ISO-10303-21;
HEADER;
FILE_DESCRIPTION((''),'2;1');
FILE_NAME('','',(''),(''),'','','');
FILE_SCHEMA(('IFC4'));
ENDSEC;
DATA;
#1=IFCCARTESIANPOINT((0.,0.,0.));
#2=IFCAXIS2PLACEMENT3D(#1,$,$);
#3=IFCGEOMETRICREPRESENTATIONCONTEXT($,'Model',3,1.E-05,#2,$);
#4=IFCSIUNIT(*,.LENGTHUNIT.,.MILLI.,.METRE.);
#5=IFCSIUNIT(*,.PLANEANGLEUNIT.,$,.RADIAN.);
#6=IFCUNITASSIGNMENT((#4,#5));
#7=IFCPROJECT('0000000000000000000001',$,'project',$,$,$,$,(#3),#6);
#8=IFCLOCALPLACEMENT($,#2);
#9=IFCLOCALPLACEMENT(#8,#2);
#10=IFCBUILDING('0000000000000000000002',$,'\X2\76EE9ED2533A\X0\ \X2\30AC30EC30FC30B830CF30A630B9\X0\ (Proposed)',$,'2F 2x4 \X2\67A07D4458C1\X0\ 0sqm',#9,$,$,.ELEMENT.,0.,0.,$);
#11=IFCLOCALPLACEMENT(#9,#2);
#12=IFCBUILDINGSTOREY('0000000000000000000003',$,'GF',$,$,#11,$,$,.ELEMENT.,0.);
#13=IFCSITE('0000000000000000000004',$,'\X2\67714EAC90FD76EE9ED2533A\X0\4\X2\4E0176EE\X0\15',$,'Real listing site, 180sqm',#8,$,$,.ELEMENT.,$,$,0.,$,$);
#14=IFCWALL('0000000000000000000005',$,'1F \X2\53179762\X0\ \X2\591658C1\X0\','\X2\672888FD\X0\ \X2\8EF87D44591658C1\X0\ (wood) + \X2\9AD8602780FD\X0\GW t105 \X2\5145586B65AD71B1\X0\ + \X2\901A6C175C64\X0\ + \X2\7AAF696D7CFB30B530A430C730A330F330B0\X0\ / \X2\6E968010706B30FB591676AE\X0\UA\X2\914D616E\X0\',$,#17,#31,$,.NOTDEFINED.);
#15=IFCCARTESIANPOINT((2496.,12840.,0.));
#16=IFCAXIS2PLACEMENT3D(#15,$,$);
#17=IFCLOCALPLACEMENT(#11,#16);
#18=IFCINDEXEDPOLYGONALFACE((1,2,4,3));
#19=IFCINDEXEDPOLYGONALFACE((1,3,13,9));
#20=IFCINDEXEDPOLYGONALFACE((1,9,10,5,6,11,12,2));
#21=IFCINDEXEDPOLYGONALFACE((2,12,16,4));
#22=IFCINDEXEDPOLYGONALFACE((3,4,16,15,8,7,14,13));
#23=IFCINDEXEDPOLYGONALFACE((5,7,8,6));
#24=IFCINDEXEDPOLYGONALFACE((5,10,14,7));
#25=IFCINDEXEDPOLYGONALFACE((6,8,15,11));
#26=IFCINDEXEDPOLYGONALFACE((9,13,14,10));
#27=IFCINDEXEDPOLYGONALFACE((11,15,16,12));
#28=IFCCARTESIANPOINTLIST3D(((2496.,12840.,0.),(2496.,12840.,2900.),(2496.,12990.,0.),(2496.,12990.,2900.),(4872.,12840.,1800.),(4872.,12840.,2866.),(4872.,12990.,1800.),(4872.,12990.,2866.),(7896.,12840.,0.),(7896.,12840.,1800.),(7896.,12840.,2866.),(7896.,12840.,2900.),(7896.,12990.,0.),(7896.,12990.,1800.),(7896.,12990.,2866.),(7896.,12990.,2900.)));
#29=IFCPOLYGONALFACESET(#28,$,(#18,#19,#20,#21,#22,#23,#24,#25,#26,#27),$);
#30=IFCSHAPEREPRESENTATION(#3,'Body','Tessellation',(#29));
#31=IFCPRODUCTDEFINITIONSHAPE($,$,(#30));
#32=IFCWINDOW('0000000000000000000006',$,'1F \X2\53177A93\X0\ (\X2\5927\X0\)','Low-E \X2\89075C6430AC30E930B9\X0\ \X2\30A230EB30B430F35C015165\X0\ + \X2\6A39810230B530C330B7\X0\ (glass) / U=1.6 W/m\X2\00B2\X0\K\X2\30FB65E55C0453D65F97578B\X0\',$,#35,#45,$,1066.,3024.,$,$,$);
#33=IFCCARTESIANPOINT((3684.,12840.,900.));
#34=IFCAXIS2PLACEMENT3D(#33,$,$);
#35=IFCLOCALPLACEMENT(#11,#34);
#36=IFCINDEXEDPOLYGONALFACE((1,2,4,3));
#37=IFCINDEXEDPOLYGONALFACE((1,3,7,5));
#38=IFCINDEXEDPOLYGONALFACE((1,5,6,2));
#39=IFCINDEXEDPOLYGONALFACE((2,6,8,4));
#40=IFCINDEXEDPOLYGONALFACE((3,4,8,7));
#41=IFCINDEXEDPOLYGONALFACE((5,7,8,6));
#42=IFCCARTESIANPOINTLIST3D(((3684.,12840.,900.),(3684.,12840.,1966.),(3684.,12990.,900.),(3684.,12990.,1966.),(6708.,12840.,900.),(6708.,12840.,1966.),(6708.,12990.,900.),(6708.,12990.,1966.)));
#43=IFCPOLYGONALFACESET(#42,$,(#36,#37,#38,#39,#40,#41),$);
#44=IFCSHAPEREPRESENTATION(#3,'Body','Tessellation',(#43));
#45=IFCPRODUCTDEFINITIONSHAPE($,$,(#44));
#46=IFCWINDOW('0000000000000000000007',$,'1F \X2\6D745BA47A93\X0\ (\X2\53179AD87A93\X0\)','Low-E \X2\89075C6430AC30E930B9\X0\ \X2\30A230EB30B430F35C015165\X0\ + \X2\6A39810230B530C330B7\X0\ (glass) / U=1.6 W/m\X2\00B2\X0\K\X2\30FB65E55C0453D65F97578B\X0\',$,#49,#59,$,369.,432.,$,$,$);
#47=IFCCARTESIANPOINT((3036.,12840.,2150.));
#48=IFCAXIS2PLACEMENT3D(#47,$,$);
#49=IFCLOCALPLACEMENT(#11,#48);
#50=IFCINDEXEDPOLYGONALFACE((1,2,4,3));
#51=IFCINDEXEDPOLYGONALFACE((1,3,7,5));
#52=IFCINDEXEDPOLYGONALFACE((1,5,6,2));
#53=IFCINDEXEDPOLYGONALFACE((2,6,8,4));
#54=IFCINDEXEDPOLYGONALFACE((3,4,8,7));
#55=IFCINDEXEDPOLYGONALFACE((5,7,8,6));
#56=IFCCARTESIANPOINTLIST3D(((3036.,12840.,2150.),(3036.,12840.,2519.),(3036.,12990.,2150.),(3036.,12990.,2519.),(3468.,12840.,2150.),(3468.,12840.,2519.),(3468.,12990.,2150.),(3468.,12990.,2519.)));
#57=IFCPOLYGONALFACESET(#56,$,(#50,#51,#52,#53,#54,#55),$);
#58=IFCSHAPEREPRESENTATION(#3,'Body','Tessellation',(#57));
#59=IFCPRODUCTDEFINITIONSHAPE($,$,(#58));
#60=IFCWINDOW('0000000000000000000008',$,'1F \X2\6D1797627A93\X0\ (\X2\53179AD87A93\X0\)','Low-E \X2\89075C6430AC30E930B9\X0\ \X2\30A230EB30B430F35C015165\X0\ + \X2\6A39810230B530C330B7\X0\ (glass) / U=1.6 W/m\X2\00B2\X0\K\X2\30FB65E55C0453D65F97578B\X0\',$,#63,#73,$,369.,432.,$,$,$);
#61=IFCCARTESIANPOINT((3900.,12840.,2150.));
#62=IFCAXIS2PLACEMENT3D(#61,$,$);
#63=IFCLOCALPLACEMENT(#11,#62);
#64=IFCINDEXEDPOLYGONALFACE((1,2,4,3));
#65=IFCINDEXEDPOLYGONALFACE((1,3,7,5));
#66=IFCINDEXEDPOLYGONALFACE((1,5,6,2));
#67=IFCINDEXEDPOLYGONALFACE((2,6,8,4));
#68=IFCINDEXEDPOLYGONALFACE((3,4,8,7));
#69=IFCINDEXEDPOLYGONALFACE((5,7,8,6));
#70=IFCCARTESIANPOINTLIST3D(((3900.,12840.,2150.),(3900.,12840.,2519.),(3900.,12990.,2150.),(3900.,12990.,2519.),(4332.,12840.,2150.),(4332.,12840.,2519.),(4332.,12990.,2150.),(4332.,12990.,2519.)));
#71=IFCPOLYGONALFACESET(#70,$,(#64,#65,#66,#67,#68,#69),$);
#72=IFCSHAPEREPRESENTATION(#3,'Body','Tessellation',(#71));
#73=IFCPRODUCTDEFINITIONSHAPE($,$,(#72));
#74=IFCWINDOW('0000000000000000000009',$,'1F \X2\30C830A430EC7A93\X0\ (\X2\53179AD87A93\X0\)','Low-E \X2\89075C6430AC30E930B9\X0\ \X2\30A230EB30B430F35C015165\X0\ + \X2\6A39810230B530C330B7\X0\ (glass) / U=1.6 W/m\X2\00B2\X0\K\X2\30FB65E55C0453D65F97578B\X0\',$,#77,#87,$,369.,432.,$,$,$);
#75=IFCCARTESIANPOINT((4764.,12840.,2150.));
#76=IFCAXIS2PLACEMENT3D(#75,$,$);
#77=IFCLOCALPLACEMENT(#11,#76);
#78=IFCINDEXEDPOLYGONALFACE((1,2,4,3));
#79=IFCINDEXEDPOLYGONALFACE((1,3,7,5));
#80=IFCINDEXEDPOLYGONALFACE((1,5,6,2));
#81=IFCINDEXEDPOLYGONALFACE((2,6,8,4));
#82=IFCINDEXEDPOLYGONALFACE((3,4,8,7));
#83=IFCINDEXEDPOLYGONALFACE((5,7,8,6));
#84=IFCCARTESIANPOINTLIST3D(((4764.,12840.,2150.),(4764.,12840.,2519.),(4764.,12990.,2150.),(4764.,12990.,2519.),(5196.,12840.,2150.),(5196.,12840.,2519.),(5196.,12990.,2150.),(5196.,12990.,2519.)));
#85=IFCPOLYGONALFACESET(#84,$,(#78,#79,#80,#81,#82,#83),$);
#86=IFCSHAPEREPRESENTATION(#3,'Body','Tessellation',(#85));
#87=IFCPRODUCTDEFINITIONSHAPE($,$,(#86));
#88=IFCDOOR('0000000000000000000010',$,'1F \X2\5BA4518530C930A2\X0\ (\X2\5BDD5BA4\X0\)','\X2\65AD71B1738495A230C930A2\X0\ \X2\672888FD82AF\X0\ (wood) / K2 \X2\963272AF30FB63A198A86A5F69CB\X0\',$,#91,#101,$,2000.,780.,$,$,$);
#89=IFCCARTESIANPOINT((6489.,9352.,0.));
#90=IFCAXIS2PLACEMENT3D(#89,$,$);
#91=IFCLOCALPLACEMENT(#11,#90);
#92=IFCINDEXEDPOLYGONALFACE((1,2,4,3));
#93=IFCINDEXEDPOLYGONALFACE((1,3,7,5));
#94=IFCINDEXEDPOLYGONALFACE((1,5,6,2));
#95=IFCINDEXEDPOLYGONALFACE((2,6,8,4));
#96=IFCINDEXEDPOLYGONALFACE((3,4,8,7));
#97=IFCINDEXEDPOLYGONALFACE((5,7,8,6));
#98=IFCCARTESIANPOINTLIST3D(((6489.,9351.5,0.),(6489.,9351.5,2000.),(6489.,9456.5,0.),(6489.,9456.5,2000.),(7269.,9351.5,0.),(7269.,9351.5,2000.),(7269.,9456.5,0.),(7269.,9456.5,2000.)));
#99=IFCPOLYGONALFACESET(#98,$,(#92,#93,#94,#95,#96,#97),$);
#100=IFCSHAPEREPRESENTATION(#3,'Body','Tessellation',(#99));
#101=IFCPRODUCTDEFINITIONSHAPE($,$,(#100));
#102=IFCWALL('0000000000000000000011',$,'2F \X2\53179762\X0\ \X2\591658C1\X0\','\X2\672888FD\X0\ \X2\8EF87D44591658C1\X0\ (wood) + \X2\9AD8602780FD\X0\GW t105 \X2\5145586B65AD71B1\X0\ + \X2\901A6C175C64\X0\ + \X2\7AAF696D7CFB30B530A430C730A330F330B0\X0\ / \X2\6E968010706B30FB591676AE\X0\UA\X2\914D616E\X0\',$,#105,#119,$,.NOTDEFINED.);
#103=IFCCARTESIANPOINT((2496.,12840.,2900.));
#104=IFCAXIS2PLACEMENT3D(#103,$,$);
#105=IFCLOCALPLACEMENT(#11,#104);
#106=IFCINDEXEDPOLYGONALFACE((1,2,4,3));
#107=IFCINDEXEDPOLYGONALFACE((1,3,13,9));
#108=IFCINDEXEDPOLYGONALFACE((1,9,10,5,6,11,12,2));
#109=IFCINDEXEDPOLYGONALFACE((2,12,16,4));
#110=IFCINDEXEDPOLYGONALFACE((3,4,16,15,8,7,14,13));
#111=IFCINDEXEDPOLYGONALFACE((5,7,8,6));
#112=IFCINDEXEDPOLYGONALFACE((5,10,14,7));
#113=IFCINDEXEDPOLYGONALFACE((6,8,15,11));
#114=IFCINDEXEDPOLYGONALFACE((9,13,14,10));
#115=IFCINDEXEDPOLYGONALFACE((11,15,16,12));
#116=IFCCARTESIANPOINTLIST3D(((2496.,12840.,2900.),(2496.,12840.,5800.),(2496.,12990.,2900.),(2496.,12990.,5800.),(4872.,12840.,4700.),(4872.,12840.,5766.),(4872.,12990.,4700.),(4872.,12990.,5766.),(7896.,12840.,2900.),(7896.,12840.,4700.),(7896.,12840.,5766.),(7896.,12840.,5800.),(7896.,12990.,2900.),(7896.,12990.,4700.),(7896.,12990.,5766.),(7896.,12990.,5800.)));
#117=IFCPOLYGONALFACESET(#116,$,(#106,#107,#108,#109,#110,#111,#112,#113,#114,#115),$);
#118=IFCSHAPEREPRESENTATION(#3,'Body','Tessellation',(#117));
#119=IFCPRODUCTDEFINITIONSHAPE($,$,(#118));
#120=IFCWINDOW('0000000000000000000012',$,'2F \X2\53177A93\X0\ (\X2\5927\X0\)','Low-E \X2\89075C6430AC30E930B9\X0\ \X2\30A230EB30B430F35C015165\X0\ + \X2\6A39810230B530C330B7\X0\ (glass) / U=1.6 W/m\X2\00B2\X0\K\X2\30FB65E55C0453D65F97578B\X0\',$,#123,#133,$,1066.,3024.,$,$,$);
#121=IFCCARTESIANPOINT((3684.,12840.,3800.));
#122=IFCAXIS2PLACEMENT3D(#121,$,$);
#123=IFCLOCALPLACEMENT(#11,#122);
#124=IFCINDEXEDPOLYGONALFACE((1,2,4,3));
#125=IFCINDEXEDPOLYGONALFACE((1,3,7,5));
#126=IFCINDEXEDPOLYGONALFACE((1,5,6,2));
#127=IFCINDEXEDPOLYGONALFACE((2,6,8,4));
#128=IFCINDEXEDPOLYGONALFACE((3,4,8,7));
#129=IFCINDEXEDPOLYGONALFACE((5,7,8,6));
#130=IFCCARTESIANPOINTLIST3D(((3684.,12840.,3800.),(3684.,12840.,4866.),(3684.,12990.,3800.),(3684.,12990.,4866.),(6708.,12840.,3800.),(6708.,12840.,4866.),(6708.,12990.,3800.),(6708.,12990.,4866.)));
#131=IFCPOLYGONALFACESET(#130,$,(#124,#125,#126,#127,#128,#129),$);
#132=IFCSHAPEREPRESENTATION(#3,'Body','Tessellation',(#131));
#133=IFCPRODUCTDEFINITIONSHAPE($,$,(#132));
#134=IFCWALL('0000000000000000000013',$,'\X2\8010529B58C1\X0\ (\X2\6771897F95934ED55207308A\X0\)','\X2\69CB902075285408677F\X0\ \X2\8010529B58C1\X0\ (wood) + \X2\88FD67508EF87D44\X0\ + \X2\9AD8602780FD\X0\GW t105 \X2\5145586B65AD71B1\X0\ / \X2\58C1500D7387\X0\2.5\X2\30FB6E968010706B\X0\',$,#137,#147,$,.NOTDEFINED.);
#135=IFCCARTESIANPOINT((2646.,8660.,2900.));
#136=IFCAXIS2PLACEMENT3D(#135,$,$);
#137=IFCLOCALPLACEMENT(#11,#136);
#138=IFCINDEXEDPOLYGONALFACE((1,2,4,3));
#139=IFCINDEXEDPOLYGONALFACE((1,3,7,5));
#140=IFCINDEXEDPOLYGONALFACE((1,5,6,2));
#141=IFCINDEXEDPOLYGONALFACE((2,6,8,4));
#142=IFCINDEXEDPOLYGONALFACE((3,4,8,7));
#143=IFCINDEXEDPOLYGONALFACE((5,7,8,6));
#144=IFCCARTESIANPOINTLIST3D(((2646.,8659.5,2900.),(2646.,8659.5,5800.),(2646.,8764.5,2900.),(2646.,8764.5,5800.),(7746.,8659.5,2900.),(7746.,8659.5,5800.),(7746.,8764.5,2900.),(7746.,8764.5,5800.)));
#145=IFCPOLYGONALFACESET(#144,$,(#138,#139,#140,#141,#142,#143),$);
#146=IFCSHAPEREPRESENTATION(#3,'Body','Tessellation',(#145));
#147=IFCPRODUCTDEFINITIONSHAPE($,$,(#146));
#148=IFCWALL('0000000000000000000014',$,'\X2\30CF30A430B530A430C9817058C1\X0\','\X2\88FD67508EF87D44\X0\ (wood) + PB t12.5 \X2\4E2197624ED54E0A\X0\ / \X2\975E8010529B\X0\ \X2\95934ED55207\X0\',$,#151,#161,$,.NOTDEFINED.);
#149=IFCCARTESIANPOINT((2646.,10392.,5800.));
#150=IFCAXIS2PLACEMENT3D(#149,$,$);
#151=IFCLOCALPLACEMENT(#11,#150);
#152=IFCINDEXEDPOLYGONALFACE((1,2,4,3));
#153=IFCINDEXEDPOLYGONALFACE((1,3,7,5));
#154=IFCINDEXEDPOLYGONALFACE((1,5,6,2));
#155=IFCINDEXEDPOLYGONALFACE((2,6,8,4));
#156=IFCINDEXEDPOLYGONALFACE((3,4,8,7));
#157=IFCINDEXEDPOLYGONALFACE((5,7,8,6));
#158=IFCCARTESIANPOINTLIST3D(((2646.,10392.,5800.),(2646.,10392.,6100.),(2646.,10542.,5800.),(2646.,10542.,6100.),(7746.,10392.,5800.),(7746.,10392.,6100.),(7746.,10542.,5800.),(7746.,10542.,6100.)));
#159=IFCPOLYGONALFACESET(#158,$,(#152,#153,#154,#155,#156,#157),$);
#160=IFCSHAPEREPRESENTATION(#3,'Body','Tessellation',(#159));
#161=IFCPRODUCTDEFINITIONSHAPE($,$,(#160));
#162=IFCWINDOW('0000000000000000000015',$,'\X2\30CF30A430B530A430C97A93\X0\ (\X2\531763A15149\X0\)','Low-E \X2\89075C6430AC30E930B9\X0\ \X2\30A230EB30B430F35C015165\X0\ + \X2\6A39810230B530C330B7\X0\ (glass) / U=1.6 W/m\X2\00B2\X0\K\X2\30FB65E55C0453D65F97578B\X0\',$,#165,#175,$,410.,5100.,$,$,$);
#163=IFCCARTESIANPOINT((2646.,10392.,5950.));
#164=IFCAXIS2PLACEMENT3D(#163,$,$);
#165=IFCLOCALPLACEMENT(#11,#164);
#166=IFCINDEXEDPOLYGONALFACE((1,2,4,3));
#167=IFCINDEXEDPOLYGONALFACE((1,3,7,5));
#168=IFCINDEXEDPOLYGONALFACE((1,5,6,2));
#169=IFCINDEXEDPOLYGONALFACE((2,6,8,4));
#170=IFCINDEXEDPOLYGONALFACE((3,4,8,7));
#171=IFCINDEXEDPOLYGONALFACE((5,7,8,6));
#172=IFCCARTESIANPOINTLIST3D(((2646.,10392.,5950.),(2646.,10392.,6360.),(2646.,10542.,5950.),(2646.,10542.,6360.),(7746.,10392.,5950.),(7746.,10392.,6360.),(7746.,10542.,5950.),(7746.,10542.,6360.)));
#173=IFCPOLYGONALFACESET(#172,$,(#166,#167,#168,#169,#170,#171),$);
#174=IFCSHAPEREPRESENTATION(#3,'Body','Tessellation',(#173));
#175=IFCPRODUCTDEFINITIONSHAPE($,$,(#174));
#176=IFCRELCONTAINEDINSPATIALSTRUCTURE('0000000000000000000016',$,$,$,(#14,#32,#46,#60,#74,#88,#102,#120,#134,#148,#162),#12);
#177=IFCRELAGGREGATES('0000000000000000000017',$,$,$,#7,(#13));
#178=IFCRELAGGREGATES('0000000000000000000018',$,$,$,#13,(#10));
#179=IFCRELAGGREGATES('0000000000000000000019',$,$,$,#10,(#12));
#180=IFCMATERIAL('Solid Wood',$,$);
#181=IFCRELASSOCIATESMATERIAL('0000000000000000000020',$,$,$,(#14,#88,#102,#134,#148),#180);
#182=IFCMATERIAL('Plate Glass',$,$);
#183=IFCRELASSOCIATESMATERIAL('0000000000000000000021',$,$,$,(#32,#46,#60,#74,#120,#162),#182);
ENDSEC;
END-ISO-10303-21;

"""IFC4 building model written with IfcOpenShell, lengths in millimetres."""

from ifc_helpers import new_model, si_unit, frame, frame_2d, origin, place, context, project, spatial, rectangle, extrude, material, element, fill, save


model = new_model("IFC4")

# Units and contexts
model_context = context("Model", 3, precision=1e-05, world=origin())
ifc_project = project(units=[si_unit("LENGTHUNIT", "METRE", prefix="MILLI"), si_unit("PLANEANGLEUNIT", "RADIAN")], contexts=[model_context])

# Site, building, storey
site_placement = place(None, origin())
site = spatial("IfcSite", under=ifc_project, at=site_placement, Name="東京都目黒区4丁目15", ObjectType="Real listing site, 180sqm", CompositionType="ELEMENT", RefElevation=0.0)
building_placement = place(site_placement, origin())
building = spatial("IfcBuilding", under=site, at=building_placement, Name="目黒区 ガレージハウス (Proposed)", ObjectType="2F 2x4 枠組壁 0sqm", CompositionType="ELEMENT", ElevationOfRefHeight=0.0, ElevationOfTerrain=0.0)
storey_placement = place(building_placement, origin())
storey = spatial("IfcBuildingStorey", under=building, at=storey_placement, Name="GF", CompositionType="ELEMENT", Elevation=0.0)

# Wall, openings, windows
ifc_material_1 = material(Name="Solid Wood")
wall_1_placement = place(storey_placement, frame((2496.0, 12840.0, 0.0)))
wall_1 = element("IfcWall", 1, at=wall_1_placement, inside=storey, material=ifc_material_1, Name="1F 北面 外壁", Description="木製 軸組外壁 (wood) + 高性能GW t105 充填断熱 + 通気層 + 窯業系サイディング / 準耐火・外皮UA配慮", PredefinedType="NOTDEFINED", context=model_context, shape_type="SweptSolid", body=[
    extrude(rectangle(XDim=5400.0, YDim=150.0, at=frame_2d((2700.0, 75.0))), frame((2496.0, 12840.0, 0.0)), (0.0, 0.0, 1.0), 2900.0),
])
opening_1_placement = place(storey_placement, frame((3684.0, 12840.0, 900.0)))
opening_1 = element("IfcOpeningElement", 2, at=opening_1_placement, cuts=wall_1, PredefinedType="NOTDEFINED", context=model_context, shape_type="SweptSolid", body=[
    extrude(rectangle(XDim=3024.0, YDim=150.0, at=frame_2d((1512.0, 75.0))), frame((3684.0, 12840.0, 900.0)), (0.0, 0.0, 1.0), 1066.0),
])
opening_2_placement = place(storey_placement, frame((3036.0, 12840.0, 2150.0)))
opening_2 = element("IfcOpeningElement", 3, at=opening_2_placement, cuts=wall_1, PredefinedType="NOTDEFINED", context=model_context, shape_type="SweptSolid", body=[
    extrude(rectangle(XDim=432.0, YDim=150.0, at=frame_2d((216.0, 75.0))), frame((3036.0, 12840.0, 2150.0)), (0.0, 0.0, 1.0), 369.0),
])
opening_3_placement = place(storey_placement, frame((3900.0, 12840.0, 2150.0)))
opening_3 = element("IfcOpeningElement", 4, at=opening_3_placement, cuts=wall_1, PredefinedType="NOTDEFINED", context=model_context, shape_type="SweptSolid", body=[
    extrude(rectangle(XDim=432.0, YDim=150.0, at=frame_2d((216.0, 75.0))), frame((3900.0, 12840.0, 2150.0)), (0.0, 0.0, 1.0), 369.0),
])
opening_4_placement = place(storey_placement, frame((4764.0, 12840.0, 2150.0)))
opening_4 = element("IfcOpeningElement", 5, at=opening_4_placement, cuts=wall_1, PredefinedType="NOTDEFINED", context=model_context, shape_type="SweptSolid", body=[
    extrude(rectangle(XDim=432.0, YDim=150.0, at=frame_2d((216.0, 75.0))), frame((4764.0, 12840.0, 2150.0)), (0.0, 0.0, 1.0), 369.0),
])
ifc_material_2 = material(Name="Plate Glass")
window_1_placement = place(storey_placement, frame((3684.0, 12840.0, 900.0)))
window_1 = element("IfcWindow", 6, at=window_1_placement, inside=storey, material=ifc_material_2, Name="1F 北窓 (大)", Description="Low-E 複層ガラス アルゴン封入 + 樹脂サッシ (glass) / U=1.6 W/m²K・日射取得型", OverallHeight=1066.0, OverallWidth=3024.0, context=model_context, shape_type="SweptSolid", body=[
    extrude(rectangle(XDim=3024.0, YDim=150.0, at=frame_2d((1512.0, 75.0))), frame((3684.0, 12840.0, 900.0)), (0.0, 0.0, 1.0), 1066.0),
])
fill(opening_1, window_1)
window_2_placement = place(storey_placement, frame((3036.0, 12840.0, 2150.0)))
window_2 = element("IfcWindow", 7, at=window_2_placement, inside=storey, material=ifc_material_2, Name="1F 浴室窓 (北高窓)", Description="Low-E 複層ガラス アルゴン封入 + 樹脂サッシ (glass) / U=1.6 W/m²K・日射取得型", OverallHeight=369.0, OverallWidth=432.0, context=model_context, shape_type="SweptSolid", body=[
    extrude(rectangle(XDim=432.0, YDim=150.0, at=frame_2d((216.0, 75.0))), frame((3036.0, 12840.0, 2150.0)), (0.0, 0.0, 1.0), 369.0),
])
fill(opening_2, window_2)
window_3_placement = place(storey_placement, frame((3900.0, 12840.0, 2150.0)))
window_3 = element("IfcWindow", 8, at=window_3_placement, inside=storey, material=ifc_material_2, Name="1F 洗面窓 (北高窓)", Description="Low-E 複層ガラス アルゴン封入 + 樹脂サッシ (glass) / U=1.6 W/m²K・日射取得型", OverallHeight=369.0, OverallWidth=432.0, context=model_context, shape_type="SweptSolid", body=[
    extrude(rectangle(XDim=432.0, YDim=150.0, at=frame_2d((216.0, 75.0))), frame((3900.0, 12840.0, 2150.0)), (0.0, 0.0, 1.0), 369.0),
])
fill(opening_3, window_3)
window_4_placement = place(storey_placement, frame((4764.0, 12840.0, 2150.0)))
window_4 = element("IfcWindow", 9, at=window_4_placement, inside=storey, material=ifc_material_2, Name="1F トイレ窓 (北高窓)", Description="Low-E 複層ガラス アルゴン封入 + 樹脂サッシ (glass) / U=1.6 W/m²K・日射取得型", OverallHeight=369.0, OverallWidth=432.0, context=model_context, shape_type="SweptSolid", body=[
    extrude(rectangle(XDim=432.0, YDim=150.0, at=frame_2d((216.0, 75.0))), frame((4764.0, 12840.0, 2150.0)), (0.0, 0.0, 1.0), 369.0),
])
fill(opening_4, window_4)

# Door
door_1_placement = place(storey_placement, frame((6489.0, 9352.0, 0.0)))
element("IfcDoor", 10, at=door_1_placement, inside=storey, material=ifc_material_1, Name="1F 室内ドア (寝室)", Description="断熱玄関ドア 木製芯 (wood) / K2 防犯・採風機構", OverallHeight=2000.0, OverallWidth=780.0, context=model_context, shape_type="SweptSolid", body=[
    extrude(rectangle(XDim=780.0, YDim=105.0, at=frame_2d((390.0, 52.0))), frame((6489.0, 9352.0, 0.0)), (0.0, 0.0, 1.0), 2000.0),
])

# Wall, opening, window
wall_2_placement = place(storey_placement, frame((2496.0, 12840.0, 2900.0)))
wall_2 = element("IfcWall", 11, at=wall_2_placement, inside=storey, material=ifc_material_1, Name="2F 北面 外壁", Description="木製 軸組外壁 (wood) + 高性能GW t105 充填断熱 + 通気層 + 窯業系サイディング / 準耐火・外皮UA配慮", PredefinedType="NOTDEFINED", context=model_context, shape_type="SweptSolid", body=[
    extrude(rectangle(XDim=5400.0, YDim=150.0, at=frame_2d((2700.0, 75.0))), frame((2496.0, 12840.0, 2900.0)), (0.0, 0.0, 1.0), 2900.0),
])
opening_5_placement = place(storey_placement, frame((3684.0, 12840.0, 3800.0)))
opening_5 = element("IfcOpeningElement", 12, at=opening_5_placement, cuts=wall_2, PredefinedType="NOTDEFINED", context=model_context, shape_type="SweptSolid", body=[
    extrude(rectangle(XDim=3024.0, YDim=150.0, at=frame_2d((1512.0, 75.0))), frame((3684.0, 12840.0, 3800.0)), (0.0, 0.0, 1.0), 1066.0),
])
window_5_placement = place(storey_placement, frame((3684.0, 12840.0, 3800.0)))
window_5 = element("IfcWindow", 13, at=window_5_placement, inside=storey, material=ifc_material_2, Name="2F 北窓 (大)", Description="Low-E 複層ガラス アルゴン封入 + 樹脂サッシ (glass) / U=1.6 W/m²K・日射取得型", OverallHeight=1066.0, OverallWidth=3024.0, context=model_context, shape_type="SweptSolid", body=[
    extrude(rectangle(XDim=3024.0, YDim=150.0, at=frame_2d((1512.0, 75.0))), frame((3684.0, 12840.0, 3800.0)), (0.0, 0.0, 1.0), 1066.0),
])
fill(opening_5, window_5)

# Wall
wall_3_placement = place(storey_placement, frame((2646.0, 8660.0, 2900.0)))
element("IfcWall", 14, at=wall_3_placement, inside=storey, material=ifc_material_1, Name="耐力壁 (東西間仕切り)", Description="構造用合板 耐力壁 (wood) + 製材軸組 + 高性能GW t105 充填断熱 / 壁倍率2.5・準耐火", PredefinedType="NOTDEFINED", context=model_context, shape_type="SweptSolid", body=[
    extrude(rectangle(XDim=5100.0, YDim=105.0, at=frame_2d((2550.0, 52.0))), frame((2646.0, 8660.0, 2900.0)), (0.0, 0.0, 1.0), 2900.0),
])

# Wall, opening, window
wall_4_placement = place(storey_placement, frame((2646.0, 10392.0, 5800.0)))
wall_4 = element("IfcWall", 15, at=wall_4_placement, inside=storey, material=ifc_material_1, Name="ハイサイド腰壁", Description="製材軸組 (wood) + PB t12.5 両面仕上 / 非耐力 間仕切", PredefinedType="NOTDEFINED", context=model_context, shape_type="SweptSolid", body=[
    extrude(rectangle(XDim=5100.0, YDim=150.0, at=frame_2d((2550.0, 75.0))), frame((2646.0, 10392.0, 5800.0)), (0.0, 0.0, 1.0), 700.0),
])
opening_6_placement = place(storey_placement, frame((2646.0, 10392.0, 5950.0)))
opening_6 = element("IfcOpeningElement", 16, at=opening_6_placement, cuts=wall_4, PredefinedType="NOTDEFINED", context=model_context, shape_type="SweptSolid", body=[
    extrude(rectangle(XDim=5100.0, YDim=150.0, at=frame_2d((2550.0, 75.0))), frame((2646.0, 10392.0, 5950.0)), (0.0, 0.0, 1.0), 410.0),
])
window_6_placement = place(storey_placement, frame((2646.0, 10392.0, 5950.0)))
window_6 = element("IfcWindow", 17, at=window_6_placement, inside=storey, material=ifc_material_2, Name="ハイサイド窓 (北採光)", Description="Low-E 複層ガラス アルゴン封入 + 樹脂サッシ (glass) / U=1.6 W/m²K・日射取得型", OverallHeight=410.0, OverallWidth=5100.0, context=model_context, shape_type="SweptSolid", body=[
    extrude(rectangle(XDim=5100.0, YDim=150.0, at=frame_2d((2550.0, 75.0))), frame((2646.0, 10392.0, 5950.0)), (0.0, 0.0, 1.0), 410.0),
])
fill(opening_6, window_6)

save(model, "model.ifc")
